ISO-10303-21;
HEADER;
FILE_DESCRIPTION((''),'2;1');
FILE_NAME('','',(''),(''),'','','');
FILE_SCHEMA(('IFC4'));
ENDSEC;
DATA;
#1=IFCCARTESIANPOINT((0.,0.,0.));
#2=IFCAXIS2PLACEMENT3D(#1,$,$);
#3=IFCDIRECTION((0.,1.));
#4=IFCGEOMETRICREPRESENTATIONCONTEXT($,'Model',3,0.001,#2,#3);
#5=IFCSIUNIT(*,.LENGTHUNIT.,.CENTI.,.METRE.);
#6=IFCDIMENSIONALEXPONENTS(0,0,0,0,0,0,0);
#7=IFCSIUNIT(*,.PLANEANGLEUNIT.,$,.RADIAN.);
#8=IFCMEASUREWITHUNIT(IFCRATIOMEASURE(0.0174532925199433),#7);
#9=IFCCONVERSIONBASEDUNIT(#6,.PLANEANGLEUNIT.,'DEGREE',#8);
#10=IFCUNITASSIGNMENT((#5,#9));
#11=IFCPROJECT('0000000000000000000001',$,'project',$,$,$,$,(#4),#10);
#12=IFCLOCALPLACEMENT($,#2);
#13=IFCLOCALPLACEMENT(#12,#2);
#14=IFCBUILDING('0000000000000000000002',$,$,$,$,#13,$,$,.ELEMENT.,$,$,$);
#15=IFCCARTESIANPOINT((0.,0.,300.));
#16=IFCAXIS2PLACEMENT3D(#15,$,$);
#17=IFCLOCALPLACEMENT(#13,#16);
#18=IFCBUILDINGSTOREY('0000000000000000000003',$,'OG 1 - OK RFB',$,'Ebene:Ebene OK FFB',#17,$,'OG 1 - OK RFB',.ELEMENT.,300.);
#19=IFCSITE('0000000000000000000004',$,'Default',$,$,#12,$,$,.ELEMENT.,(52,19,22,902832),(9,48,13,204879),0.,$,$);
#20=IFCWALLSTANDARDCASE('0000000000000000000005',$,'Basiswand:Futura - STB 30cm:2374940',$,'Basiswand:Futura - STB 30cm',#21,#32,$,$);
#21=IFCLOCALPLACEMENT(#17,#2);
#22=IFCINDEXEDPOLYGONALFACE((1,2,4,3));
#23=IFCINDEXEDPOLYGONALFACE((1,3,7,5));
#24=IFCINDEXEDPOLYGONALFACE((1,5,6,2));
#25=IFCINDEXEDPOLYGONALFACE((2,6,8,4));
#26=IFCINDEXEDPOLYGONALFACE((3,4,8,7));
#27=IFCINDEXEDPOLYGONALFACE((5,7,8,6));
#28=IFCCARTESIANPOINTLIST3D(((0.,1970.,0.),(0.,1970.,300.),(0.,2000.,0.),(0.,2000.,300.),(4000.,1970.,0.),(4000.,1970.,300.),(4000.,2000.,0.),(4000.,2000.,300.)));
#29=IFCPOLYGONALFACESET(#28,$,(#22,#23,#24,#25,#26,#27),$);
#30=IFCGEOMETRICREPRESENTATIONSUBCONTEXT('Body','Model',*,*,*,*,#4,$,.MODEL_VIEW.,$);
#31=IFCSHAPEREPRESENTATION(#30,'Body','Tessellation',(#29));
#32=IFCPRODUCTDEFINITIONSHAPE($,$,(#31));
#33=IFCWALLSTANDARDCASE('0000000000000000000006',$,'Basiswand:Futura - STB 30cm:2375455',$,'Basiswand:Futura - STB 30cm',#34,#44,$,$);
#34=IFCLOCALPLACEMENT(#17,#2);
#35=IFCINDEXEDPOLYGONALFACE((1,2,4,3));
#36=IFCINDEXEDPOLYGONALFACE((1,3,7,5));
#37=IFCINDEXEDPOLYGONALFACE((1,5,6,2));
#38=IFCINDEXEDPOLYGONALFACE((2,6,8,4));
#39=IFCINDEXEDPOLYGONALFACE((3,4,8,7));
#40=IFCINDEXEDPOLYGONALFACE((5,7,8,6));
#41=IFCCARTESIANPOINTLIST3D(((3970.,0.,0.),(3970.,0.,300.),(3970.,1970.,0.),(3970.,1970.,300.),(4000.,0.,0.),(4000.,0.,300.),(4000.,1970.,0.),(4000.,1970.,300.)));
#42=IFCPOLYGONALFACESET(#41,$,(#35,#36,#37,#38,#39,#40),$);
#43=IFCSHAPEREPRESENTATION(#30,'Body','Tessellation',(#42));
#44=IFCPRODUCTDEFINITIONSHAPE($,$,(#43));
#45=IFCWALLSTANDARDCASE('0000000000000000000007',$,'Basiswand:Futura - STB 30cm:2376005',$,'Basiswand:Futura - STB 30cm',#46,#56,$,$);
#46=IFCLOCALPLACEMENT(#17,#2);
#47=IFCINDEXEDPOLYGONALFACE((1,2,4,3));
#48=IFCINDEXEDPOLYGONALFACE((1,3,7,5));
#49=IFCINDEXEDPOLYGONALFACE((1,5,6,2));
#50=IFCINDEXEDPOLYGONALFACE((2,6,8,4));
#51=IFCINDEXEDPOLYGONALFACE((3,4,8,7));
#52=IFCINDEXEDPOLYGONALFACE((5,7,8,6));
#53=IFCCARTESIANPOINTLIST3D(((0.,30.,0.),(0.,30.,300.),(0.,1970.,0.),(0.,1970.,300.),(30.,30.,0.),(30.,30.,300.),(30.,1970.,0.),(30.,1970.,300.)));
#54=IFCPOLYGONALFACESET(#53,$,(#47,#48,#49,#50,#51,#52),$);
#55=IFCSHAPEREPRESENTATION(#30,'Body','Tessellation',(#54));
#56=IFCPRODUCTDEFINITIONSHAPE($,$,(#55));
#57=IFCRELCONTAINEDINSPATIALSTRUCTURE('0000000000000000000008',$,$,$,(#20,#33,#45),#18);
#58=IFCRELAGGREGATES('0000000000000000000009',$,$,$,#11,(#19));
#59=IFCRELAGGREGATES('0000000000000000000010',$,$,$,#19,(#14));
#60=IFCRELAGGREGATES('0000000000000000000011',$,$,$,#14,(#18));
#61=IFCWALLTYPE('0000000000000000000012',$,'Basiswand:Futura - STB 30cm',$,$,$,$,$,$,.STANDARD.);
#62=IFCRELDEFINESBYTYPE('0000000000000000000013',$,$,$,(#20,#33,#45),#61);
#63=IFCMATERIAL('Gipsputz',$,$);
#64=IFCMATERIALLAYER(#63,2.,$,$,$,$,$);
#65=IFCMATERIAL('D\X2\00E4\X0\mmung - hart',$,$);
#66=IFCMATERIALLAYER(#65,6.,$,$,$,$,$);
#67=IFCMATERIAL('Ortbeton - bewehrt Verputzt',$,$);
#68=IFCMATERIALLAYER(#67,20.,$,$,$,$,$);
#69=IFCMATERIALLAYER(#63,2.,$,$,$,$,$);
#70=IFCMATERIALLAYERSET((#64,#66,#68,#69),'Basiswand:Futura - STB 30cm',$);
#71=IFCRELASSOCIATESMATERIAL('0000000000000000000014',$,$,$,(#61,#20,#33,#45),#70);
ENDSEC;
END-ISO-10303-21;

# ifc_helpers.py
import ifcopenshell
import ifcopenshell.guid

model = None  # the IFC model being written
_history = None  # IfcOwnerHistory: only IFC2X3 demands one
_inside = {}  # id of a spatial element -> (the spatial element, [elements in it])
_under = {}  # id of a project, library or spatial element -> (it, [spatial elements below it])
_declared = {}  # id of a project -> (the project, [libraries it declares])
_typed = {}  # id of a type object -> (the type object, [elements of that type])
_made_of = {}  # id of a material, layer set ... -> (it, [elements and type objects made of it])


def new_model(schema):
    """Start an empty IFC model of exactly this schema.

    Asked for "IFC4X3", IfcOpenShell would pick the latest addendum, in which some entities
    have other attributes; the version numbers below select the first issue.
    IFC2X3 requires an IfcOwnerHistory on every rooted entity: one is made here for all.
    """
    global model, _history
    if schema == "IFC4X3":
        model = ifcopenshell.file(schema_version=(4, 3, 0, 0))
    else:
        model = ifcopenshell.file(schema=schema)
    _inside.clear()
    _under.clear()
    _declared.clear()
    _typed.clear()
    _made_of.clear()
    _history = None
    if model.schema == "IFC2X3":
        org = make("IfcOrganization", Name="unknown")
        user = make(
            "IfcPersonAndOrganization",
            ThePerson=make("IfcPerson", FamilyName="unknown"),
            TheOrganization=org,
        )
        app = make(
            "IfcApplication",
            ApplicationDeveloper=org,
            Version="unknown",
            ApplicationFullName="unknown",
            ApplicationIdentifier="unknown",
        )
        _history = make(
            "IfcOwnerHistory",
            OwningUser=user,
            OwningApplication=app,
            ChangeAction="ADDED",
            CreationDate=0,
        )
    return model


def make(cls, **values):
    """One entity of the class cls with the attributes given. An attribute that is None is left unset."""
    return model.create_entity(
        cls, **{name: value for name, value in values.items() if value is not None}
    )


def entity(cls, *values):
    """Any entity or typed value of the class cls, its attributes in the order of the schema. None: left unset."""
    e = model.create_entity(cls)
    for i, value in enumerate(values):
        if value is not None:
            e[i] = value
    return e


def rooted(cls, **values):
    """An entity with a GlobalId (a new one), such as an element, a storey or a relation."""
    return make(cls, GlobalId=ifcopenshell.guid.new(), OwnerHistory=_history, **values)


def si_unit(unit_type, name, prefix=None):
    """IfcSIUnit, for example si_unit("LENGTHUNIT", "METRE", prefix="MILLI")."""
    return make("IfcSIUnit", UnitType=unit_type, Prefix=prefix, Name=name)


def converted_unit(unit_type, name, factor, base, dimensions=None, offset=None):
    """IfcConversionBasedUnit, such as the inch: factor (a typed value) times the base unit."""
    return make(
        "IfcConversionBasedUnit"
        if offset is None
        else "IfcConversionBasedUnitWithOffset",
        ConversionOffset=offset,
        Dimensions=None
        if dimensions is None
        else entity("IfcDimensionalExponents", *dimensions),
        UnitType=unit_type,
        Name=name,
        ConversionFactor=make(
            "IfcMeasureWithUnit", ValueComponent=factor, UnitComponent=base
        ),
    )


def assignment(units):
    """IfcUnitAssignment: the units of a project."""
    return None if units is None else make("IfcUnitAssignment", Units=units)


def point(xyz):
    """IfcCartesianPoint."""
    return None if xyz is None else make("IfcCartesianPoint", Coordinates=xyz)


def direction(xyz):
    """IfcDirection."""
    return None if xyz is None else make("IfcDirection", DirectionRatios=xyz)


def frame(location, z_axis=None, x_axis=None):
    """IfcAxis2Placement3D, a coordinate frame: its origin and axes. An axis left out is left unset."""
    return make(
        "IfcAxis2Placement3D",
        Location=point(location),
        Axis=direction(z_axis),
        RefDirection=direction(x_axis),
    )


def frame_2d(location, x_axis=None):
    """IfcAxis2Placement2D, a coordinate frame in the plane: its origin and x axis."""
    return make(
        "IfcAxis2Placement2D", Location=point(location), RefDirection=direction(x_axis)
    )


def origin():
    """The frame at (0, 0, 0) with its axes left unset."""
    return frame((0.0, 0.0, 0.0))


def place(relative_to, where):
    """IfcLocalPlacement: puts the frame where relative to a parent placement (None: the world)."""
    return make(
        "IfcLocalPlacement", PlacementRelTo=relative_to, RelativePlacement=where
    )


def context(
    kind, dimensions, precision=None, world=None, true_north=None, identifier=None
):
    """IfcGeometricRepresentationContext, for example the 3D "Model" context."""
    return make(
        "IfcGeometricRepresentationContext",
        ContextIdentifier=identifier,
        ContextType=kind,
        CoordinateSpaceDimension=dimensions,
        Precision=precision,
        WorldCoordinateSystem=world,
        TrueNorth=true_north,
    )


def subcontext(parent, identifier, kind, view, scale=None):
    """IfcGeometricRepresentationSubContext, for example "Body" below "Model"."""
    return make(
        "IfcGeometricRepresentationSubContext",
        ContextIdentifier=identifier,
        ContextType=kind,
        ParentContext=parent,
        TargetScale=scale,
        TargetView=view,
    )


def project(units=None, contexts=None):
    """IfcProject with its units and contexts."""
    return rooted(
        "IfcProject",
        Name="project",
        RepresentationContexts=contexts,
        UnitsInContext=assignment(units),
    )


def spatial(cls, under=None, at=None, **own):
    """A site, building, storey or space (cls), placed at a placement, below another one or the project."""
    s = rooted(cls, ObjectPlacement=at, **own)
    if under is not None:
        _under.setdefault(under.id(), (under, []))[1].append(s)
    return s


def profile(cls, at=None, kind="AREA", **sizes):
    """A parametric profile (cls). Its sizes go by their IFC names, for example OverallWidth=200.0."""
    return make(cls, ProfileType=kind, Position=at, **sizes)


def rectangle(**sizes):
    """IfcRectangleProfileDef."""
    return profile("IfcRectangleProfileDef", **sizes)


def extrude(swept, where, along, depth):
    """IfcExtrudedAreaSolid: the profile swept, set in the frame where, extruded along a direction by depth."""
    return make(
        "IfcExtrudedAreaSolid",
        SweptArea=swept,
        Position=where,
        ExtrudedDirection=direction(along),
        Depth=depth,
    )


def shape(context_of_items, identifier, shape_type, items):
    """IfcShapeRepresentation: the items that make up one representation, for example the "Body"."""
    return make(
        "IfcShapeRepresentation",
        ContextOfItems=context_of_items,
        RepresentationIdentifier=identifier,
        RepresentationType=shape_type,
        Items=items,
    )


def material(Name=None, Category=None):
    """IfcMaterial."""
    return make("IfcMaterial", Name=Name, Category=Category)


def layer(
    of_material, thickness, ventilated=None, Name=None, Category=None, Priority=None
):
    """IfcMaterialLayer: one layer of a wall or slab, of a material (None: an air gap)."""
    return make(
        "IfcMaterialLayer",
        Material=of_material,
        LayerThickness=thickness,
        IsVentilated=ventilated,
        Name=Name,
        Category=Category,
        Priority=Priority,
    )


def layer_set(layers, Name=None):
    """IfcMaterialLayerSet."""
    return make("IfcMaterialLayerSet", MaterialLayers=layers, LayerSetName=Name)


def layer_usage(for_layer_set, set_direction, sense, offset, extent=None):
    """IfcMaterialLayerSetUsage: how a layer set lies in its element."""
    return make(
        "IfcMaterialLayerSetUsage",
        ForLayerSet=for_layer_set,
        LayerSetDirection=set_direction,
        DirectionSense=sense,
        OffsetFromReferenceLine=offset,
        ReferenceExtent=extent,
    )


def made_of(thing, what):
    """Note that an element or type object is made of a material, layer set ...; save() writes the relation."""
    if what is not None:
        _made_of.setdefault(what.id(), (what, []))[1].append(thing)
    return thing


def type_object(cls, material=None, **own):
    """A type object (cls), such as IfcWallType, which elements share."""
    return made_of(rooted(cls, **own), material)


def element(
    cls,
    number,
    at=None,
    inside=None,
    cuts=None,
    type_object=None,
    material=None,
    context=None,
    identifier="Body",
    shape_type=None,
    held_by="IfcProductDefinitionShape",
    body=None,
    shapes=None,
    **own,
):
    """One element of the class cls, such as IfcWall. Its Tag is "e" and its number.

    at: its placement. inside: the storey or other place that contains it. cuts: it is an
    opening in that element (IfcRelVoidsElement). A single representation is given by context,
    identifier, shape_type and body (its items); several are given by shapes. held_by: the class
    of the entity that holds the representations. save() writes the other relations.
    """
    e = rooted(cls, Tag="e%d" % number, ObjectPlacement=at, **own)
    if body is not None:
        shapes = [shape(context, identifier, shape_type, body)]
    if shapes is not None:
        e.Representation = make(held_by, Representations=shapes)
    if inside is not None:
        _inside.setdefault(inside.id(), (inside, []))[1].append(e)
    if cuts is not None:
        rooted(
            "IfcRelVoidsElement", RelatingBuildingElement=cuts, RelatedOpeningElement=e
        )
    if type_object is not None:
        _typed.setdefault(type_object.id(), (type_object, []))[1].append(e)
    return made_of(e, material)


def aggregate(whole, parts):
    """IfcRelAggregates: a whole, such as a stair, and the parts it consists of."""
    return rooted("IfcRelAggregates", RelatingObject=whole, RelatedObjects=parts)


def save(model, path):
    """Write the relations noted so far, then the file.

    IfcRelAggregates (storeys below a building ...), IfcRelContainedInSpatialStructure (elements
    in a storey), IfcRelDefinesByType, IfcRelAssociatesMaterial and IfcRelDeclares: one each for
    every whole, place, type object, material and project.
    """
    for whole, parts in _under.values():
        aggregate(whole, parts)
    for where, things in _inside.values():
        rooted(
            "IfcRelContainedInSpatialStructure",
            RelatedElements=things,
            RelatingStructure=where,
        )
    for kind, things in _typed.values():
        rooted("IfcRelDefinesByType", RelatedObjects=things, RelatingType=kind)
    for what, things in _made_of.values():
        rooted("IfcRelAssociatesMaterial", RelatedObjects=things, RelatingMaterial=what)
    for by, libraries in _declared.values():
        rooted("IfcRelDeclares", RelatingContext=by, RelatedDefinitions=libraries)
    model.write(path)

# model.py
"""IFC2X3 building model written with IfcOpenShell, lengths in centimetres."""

from ifc_helpers import new_model, entity, si_unit, converted_unit, direction, frame, frame_2d, origin, place, context, subcontext, project, spatial, rectangle, extrude, material, layer, layer_set, layer_usage, type_object, element, save


model = new_model("IFC2X3")

# Units and contexts
model_context = context("Model", 3, precision=0.001, world=origin(), true_north=direction((0.0, 1.0)))
body_context = subcontext(model_context, "Body", "Model", "MODEL_VIEW")
ifc_project = project(units=[si_unit("LENGTHUNIT", "METRE", prefix="CENTI"), converted_unit("PLANEANGLEUNIT", "DEGREE", entity("IfcRatioMeasure", 0.0174532925199433), si_unit("PLANEANGLEUNIT", "RADIAN"), dimensions=[0, 0, 0, 0, 0, 0, 0])], contexts=[model_context])

# Site, building, storey
site_placement = place(None, frame((0.0, 0.0, 0.0)))
site = spatial("IfcSite", under=ifc_project, at=site_placement, Name="Default", CompositionType="ELEMENT", RefLatitude=(52, 19, 22, 902832), RefLongitude=(9, 48, 13, 204879), RefElevation=0.0)
building_placement = place(site_placement, origin())
building = spatial("IfcBuilding", under=site, at=building_placement, CompositionType="ELEMENT")
storey_placement = place(building_placement, frame((0.0, 0.0, 300.0)))
storey = spatial("IfcBuildingStorey", under=building, at=storey_placement, Name="OG 1 - OK RFB", ObjectType="Ebene:Ebene OK FFB", LongName="OG 1 - OK RFB", CompositionType="ELEMENT", Elevation=300.0)

# Walls
ifc_material_1 = material(Name="Gipsputz")
ifc_layer_1 = layer(ifc_material_1, 2.0)
ifc_material_2 = material(Name="Dämmung - hart")
ifc_layer_2 = layer(ifc_material_2, 6.0)
ifc_material_3 = material(Name="Ortbeton - bewehrt Verputzt")
ifc_layer_3 = layer(ifc_material_3, 20.0)
ifc_layer_4 = layer(ifc_material_1, 2.0)
ifc_layer_set = layer_set([ifc_layer_1, ifc_layer_2, ifc_layer_3, ifc_layer_4], Name="Basiswand:Futura - STB 30cm")
ifc_layer_usage_1 = layer_usage(ifc_layer_set, "AXIS2", "NEGATIVE", 15.0)
wall_type = type_object("IfcWallType", Name="Basiswand:Futura - STB 30cm", PredefinedType="STANDARD", material=ifc_layer_set)
wall_1_placement = place(storey_placement, frame((0.0, 1985.0, 0.0)))
element("IfcWallStandardCase", 1, at=wall_1_placement, inside=storey, type_object=wall_type, material=ifc_layer_usage_1, Name="Basiswand:Futura - STB 30cm:2374940", ObjectType="Basiswand:Futura - STB 30cm", context=body_context, shape_type="SweptSolid", body=[
    extrude(rectangle(XDim=4000.0, YDim=30.0, at=frame_2d((2000.0, 0.0), x_axis=(-1.0, 0.0))), origin(), (0.0, 0.0, 1.0), 300.0),
])
ifc_layer_usage_2 = layer_usage(ifc_layer_set, "AXIS2", "NEGATIVE", 15.0)
wall_2_placement = place(storey_placement, frame((3985.0, 1970.0, 0.0), z_axis=(0.0, 0.0, 1.0), x_axis=(0.0, -1.0, 0.0)))
element("IfcWallStandardCase", 2, at=wall_2_placement, inside=storey, type_object=wall_type, material=ifc_layer_usage_2, Name="Basiswand:Futura - STB 30cm:2375455", ObjectType="Basiswand:Futura - STB 30cm", context=body_context, shape_type="SweptSolid", body=[
    extrude(rectangle(XDim=1970.0, YDim=30.0, at=frame_2d((985.0, 0.0), x_axis=(-1.0, 0.0))), origin(), (0.0, 0.0, 1.0), 300.0),
])
ifc_layer_usage_3 = layer_usage(ifc_layer_set, "AXIS2", "NEGATIVE", 15.0)
wall_3_placement = place(storey_placement, frame((15.0, 30.0, 0.0), z_axis=(0.0, 0.0, 1.0), x_axis=(0.0, 1.0, 0.0)))
element("IfcWallStandardCase", 3, at=wall_3_placement, inside=storey, type_object=wall_type, material=ifc_layer_usage_3, Name="Basiswand:Futura - STB 30cm:2376005", ObjectType="Basiswand:Futura - STB 30cm", context=body_context, shape_type="SweptSolid", body=[
    extrude(rectangle(XDim=1940.0, YDim=30.0, at=frame_2d((970.0, 0.0), x_axis=(-1.0, 0.0))), origin(), (0.0, 0.0, 1.0), 300.0),
])

save(model, "model.ifc")
